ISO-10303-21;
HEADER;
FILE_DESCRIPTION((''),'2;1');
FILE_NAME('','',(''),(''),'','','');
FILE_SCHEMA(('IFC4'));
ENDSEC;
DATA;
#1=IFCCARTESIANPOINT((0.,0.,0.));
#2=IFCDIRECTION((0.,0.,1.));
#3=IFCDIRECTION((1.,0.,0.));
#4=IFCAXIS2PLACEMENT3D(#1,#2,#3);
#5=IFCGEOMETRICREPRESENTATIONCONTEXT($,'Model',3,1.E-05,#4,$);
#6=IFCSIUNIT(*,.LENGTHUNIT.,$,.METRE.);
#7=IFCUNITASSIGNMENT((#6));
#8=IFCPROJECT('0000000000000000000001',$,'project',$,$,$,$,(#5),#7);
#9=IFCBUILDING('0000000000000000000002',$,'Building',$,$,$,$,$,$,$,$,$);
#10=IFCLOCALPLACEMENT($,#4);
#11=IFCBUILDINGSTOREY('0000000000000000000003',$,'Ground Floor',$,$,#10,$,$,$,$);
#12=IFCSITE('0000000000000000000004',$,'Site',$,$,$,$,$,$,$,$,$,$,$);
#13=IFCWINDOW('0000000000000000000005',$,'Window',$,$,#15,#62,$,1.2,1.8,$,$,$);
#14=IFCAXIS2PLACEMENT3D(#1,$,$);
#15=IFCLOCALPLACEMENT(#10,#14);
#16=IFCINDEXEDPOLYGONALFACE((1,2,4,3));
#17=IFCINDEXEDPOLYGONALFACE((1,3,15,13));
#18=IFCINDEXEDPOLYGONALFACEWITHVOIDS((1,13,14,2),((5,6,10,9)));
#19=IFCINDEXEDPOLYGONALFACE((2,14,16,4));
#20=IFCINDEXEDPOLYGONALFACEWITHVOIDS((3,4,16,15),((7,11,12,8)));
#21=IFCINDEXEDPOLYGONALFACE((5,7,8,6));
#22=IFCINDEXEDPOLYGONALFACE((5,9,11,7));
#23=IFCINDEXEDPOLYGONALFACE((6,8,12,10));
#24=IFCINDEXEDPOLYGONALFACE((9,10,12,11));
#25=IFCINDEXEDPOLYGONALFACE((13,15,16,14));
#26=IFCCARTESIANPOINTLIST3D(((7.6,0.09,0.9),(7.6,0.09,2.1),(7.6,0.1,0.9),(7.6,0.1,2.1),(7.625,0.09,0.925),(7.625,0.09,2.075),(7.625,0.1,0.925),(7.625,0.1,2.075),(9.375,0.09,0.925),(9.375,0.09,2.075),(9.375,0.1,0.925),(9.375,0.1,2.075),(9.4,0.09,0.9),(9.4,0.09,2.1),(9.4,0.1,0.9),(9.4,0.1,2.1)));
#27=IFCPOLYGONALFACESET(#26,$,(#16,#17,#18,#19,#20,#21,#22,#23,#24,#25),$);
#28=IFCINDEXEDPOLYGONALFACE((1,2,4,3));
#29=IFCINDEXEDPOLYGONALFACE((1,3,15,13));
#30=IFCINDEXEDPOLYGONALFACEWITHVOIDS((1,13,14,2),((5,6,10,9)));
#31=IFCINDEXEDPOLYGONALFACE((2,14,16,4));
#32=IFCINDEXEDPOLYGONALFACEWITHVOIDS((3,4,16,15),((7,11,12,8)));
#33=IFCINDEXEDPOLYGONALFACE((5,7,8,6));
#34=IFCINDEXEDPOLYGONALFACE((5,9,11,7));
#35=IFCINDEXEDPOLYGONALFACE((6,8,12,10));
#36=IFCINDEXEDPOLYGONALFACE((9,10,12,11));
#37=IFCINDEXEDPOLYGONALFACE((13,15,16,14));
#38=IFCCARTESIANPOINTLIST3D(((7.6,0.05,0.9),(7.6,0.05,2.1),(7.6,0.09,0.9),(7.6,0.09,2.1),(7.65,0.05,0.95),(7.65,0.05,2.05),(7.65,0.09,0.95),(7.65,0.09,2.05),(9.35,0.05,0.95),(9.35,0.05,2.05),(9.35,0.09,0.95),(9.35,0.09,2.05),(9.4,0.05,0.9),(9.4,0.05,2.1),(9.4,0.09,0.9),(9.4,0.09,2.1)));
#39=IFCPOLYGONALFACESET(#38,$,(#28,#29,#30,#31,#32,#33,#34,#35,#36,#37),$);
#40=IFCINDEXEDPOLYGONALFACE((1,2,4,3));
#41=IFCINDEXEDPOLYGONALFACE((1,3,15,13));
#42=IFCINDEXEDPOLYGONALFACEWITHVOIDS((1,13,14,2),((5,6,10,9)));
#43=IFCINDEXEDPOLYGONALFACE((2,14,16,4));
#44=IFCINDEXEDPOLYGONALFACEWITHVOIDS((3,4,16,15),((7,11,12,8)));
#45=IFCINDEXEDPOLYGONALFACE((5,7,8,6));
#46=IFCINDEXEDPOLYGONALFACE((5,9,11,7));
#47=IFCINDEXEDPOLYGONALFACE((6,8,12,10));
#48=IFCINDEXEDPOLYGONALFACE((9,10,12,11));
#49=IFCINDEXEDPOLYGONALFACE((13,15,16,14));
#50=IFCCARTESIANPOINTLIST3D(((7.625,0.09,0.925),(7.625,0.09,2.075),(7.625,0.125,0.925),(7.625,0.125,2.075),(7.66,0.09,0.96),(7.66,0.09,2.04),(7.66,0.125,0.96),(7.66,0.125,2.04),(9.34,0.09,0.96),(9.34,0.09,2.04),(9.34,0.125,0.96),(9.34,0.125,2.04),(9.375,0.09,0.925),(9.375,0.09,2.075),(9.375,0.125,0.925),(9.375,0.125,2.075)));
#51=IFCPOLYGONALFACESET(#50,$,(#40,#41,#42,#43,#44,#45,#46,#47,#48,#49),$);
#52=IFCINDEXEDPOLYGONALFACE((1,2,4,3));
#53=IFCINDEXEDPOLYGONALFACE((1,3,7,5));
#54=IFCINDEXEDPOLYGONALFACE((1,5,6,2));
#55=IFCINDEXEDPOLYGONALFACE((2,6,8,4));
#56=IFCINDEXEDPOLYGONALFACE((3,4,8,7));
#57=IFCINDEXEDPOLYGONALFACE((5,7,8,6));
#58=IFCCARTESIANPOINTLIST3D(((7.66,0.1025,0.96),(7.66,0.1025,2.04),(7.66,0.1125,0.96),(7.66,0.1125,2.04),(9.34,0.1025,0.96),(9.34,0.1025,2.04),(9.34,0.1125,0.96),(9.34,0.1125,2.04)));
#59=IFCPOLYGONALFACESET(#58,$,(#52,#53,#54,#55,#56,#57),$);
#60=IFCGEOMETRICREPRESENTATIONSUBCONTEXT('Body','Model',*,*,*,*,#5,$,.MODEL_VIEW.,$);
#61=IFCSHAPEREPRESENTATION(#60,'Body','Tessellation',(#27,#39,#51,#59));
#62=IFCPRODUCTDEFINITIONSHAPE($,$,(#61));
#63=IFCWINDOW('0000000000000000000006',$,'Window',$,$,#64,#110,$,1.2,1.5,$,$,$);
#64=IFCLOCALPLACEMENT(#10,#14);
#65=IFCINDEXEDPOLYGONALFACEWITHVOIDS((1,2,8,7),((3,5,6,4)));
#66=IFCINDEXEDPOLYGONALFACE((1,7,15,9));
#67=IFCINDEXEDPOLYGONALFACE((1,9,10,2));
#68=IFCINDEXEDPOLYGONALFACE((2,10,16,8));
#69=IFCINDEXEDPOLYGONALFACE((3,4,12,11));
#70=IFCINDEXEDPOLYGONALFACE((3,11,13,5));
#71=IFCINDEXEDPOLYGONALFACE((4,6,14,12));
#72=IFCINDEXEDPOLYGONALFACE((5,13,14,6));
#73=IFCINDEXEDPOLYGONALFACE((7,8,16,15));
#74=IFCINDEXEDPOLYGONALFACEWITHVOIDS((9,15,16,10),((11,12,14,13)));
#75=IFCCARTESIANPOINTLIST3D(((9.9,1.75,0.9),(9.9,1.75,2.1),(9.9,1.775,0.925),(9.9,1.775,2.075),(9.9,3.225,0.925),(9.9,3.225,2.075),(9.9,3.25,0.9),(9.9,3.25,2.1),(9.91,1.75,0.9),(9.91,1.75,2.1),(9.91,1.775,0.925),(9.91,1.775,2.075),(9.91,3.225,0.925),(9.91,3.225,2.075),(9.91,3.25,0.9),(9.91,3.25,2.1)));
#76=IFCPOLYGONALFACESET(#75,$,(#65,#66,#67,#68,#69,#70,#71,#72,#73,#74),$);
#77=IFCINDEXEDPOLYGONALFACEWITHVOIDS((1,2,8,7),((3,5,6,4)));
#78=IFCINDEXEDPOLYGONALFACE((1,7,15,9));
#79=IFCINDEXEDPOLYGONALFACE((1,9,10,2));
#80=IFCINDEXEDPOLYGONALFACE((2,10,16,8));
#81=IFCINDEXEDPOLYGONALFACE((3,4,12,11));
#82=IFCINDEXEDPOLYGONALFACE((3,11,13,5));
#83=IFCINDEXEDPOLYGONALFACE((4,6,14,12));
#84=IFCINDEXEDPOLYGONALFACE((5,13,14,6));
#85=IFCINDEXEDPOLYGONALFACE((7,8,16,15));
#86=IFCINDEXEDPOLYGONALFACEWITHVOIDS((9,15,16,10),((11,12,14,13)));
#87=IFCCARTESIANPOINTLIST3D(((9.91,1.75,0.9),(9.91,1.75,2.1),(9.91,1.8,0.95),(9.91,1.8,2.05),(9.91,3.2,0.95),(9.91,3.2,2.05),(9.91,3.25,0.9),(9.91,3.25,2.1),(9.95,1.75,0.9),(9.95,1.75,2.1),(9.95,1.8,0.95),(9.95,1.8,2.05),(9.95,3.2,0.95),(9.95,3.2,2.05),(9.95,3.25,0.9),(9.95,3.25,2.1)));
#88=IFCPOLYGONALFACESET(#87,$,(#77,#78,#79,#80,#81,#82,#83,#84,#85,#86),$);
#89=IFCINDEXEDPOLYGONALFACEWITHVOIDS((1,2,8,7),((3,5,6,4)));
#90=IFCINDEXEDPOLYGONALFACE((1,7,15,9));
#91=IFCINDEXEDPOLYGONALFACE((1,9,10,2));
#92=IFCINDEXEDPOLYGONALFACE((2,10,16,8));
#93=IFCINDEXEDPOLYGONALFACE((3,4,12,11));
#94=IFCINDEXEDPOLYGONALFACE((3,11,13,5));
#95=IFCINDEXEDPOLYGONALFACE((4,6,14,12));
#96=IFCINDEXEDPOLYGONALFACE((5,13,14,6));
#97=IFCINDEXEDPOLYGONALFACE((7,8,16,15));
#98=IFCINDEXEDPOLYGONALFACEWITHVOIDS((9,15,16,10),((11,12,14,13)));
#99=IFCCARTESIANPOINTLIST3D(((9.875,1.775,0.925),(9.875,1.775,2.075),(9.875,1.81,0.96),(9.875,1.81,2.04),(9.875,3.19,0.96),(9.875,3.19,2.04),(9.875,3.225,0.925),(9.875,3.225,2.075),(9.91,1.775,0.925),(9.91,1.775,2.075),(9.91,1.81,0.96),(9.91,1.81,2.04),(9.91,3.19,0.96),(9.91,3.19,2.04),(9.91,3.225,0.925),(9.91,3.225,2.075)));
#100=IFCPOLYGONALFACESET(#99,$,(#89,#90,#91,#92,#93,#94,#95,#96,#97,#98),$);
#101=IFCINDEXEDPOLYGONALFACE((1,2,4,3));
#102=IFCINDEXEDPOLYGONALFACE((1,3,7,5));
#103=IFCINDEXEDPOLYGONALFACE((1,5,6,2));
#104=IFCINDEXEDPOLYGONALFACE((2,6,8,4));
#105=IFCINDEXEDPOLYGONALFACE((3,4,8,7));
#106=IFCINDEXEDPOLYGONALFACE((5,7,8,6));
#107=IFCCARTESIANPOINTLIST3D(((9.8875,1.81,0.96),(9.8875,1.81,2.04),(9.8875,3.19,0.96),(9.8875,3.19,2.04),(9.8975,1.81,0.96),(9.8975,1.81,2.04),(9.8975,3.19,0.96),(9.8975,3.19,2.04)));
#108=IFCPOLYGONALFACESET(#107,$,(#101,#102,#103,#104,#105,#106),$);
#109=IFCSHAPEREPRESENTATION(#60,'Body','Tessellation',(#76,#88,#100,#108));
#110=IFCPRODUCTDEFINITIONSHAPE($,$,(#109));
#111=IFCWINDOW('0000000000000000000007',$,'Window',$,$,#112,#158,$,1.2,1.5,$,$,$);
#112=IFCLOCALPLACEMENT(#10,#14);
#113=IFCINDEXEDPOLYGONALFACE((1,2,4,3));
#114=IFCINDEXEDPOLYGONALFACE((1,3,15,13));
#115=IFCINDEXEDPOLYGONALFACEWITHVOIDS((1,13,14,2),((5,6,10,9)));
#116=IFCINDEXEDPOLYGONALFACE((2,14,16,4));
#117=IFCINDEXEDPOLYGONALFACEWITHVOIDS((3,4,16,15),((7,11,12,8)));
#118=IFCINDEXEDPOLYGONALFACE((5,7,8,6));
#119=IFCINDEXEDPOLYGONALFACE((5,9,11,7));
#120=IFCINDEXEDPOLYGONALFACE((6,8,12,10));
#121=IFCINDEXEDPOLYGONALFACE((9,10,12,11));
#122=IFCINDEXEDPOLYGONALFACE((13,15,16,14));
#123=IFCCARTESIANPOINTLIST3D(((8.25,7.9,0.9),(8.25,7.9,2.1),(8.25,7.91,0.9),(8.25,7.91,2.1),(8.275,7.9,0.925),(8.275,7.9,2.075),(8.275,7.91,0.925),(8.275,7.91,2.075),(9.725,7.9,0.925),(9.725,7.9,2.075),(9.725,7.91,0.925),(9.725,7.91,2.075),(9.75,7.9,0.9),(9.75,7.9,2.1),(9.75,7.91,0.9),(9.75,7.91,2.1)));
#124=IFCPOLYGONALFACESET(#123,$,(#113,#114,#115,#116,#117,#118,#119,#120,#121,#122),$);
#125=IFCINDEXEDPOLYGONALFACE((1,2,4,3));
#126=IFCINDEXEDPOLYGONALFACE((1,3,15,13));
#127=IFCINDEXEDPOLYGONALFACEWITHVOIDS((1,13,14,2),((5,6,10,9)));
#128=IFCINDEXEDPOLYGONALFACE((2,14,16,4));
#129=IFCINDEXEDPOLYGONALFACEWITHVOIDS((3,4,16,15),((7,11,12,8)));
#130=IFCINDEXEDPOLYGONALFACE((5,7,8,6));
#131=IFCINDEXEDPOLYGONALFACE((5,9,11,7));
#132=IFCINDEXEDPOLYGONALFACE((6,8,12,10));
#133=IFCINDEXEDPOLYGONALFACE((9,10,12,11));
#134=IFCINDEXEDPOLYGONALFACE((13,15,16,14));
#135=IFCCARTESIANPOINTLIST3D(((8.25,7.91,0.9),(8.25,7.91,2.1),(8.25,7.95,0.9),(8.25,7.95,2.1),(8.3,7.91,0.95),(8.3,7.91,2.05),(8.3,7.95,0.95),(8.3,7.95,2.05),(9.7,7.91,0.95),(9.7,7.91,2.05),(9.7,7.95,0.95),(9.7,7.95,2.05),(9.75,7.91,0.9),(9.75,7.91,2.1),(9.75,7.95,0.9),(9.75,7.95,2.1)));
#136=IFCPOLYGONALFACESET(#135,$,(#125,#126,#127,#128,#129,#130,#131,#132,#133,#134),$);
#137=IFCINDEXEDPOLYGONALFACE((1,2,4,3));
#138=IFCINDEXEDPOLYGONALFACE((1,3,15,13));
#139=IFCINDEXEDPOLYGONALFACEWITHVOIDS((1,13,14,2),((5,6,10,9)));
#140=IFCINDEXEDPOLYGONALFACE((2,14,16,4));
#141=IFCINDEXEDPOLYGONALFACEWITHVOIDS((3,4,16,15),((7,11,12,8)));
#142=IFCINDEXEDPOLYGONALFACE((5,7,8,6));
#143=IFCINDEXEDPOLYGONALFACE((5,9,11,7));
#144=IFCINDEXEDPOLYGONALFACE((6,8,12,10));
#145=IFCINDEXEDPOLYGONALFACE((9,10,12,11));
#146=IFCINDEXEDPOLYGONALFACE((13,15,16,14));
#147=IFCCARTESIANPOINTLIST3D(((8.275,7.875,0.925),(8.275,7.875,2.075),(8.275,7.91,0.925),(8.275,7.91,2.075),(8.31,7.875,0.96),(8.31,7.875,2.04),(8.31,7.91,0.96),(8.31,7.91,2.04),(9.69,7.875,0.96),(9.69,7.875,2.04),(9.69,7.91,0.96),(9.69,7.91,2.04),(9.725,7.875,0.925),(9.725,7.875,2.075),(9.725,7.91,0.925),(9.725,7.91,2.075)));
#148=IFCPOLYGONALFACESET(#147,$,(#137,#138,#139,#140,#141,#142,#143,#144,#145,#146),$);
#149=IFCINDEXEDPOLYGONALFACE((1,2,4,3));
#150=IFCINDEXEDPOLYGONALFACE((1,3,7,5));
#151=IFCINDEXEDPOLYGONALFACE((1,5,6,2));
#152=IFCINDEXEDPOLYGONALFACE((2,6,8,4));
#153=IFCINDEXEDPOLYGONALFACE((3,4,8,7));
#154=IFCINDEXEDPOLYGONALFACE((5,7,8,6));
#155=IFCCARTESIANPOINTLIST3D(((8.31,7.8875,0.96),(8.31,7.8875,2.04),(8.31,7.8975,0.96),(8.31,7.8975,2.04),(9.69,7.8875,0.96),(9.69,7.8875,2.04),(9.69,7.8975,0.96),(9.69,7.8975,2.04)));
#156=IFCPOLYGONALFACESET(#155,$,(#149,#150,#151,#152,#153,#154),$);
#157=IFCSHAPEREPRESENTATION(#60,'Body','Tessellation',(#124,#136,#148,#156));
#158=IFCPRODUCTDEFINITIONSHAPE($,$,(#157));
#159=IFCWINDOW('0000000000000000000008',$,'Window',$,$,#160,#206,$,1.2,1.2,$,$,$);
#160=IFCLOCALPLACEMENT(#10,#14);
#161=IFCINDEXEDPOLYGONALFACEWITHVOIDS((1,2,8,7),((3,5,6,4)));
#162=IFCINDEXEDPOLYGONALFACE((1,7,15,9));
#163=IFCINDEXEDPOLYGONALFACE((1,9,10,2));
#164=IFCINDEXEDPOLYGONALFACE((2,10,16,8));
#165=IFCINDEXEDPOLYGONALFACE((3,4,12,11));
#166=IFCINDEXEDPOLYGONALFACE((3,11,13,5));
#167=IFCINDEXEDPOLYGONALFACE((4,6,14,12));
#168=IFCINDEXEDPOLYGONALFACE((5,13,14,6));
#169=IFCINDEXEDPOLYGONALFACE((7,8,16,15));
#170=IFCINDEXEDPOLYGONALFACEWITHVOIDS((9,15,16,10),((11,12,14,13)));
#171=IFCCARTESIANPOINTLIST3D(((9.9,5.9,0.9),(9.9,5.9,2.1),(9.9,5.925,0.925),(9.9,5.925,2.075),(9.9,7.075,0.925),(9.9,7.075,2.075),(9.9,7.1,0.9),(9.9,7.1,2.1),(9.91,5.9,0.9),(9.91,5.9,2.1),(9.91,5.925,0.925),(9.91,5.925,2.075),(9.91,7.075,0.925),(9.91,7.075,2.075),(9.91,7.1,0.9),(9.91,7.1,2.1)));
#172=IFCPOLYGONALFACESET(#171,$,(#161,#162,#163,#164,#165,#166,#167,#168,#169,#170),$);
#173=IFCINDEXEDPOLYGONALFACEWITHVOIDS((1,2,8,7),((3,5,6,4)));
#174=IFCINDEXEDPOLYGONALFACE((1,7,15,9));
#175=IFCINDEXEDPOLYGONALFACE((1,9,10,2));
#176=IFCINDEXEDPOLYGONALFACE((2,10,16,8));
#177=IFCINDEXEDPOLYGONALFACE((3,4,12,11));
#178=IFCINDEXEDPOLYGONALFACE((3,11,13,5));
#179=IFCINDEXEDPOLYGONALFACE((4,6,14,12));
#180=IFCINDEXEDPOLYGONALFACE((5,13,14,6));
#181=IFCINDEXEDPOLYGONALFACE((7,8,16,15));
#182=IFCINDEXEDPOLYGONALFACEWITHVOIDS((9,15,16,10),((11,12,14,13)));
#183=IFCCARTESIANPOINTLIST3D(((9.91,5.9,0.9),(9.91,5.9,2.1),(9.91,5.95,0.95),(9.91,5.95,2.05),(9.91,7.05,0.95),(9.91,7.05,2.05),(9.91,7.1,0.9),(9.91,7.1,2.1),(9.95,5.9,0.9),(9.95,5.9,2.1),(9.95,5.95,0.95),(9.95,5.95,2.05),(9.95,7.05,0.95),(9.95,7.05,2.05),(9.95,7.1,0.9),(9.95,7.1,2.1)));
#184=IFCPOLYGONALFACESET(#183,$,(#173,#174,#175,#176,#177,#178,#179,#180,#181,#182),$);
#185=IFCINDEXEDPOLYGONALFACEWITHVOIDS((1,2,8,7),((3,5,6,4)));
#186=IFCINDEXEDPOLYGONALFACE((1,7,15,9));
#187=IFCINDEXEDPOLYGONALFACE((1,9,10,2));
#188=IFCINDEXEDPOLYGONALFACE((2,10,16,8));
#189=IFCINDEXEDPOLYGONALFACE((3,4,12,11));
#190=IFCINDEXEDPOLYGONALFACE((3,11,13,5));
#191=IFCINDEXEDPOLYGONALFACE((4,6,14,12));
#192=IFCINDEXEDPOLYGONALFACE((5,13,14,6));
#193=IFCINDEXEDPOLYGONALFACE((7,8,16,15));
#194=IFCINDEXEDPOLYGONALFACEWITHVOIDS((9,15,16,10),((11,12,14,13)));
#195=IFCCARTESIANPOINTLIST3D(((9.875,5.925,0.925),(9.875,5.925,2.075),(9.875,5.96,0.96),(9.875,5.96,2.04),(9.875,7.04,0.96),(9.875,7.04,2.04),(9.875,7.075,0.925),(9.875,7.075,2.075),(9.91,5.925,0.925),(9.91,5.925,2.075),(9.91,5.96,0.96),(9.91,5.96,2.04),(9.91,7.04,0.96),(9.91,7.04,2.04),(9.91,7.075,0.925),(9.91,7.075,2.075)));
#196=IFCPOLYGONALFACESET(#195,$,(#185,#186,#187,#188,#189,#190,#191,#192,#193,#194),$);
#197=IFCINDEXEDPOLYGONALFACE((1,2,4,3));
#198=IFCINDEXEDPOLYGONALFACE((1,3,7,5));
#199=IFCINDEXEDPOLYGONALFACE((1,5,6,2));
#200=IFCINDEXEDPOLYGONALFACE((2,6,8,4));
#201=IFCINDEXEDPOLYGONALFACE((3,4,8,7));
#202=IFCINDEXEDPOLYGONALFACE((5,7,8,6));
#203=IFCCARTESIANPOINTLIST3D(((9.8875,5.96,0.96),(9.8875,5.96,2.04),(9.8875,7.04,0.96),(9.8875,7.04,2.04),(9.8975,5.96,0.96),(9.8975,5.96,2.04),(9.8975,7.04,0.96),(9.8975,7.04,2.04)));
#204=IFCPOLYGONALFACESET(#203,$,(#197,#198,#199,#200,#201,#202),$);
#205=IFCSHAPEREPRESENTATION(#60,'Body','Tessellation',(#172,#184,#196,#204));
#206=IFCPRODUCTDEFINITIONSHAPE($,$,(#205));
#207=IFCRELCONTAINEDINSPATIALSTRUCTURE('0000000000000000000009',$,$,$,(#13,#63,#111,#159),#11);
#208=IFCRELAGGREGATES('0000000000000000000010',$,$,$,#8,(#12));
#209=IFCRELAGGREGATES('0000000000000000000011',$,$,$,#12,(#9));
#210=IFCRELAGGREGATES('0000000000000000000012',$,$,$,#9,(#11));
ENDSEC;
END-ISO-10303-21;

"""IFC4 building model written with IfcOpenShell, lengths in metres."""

from ifc_helpers import new_model, si_unit, frame, origin_with_axes, place, context, subcontext, project, spatial, line, indexed_curve, outline, extrude, element, save


model = new_model("IFC4")

# Units and contexts
model_context = context("Model", 3, precision=1e-05, world=origin_with_axes())
body_context = subcontext(model_context, "Body", "Model", "MODEL_VIEW")
ifc_project = project(units=[si_unit("LENGTHUNIT", "METRE")], contexts=[model_context])

# Site, building, storey
site = spatial("IfcSite", under=ifc_project, Name="Site")
building = spatial("IfcBuilding", under=site, Name="Building")
storey_placement = place(None, origin_with_axes())
storey = spatial("IfcBuildingStorey", under=building, at=storey_placement, Name="Ground Floor")

# Windows
window_1_placement = place(storey_placement, frame((7.6, 0.0, 0.9), z_axis=(0.0, 0.0, 1.0), x_axis=(1.0, 0.0, 0.0)))
element("IfcWindow", 1, at=window_1_placement, inside=storey, Name="Window", OverallHeight=1.2, OverallWidth=1.8, context=body_context, shape_type="SweptSolid", body=[
    extrude(outline(indexed_curve([(0.0, 0.0), (1.8, 0.0), (1.8, 1.2), (0.0, 1.2)], segments=[line(1, 2, 3, 4, 1)]), holes=[indexed_curve([(0.025, 0.025), (1.775, 0.025), (1.775, 1.175), (0.025, 1.175)], segments=[line(1, 2, 3, 4, 1)])]), frame((0.0, 0.09, 0.0), z_axis=(0.0, -1.0, 0.0), x_axis=(1.0, 0.0, 0.0)), (0.0, 0.0, -1.0), 0.01),
    extrude(outline(indexed_curve([(0.0, 0.0), (1.8, 0.0), (1.8, 1.2), (0.0, 1.2)], segments=[line(1, 2, 3, 4, 1)]), holes=[indexed_curve([(0.05, 0.05), (1.75, 0.05), (1.75, 1.15), (0.05, 1.15)], segments=[line(1, 2, 3, 4, 1)])]), frame((0.0, 0.05, 0.0), z_axis=(0.0, -1.0, 0.0), x_axis=(1.0, 0.0, 0.0)), (0.0, 0.0, -1.0), 0.04),
    extrude(outline(indexed_curve([(0.0, 0.0), (1.75, 0.0), (1.75, 1.15), (0.0, 1.15)], segments=[line(1, 2, 3, 4, 1)]), holes=[indexed_curve([(0.035, 0.035), (1.715, 0.035), (1.715, 1.115), (0.035, 1.115)], segments=[line(1, 2, 3, 4, 1)])]), frame((0.025, 0.09, 0.025), z_axis=(0.0, -1.0, 0.0), x_axis=(1.0, 0.0, 0.0)), (0.0, 0.0, -1.0), 0.035),
    extrude(outline(indexed_curve([(0.035, 0.035), (1.715, 0.035), (1.715, 1.115), (0.035, 1.115)], segments=[line(1, 2, 3, 4, 1)])), frame((0.025, 0.1025, 0.025), z_axis=(0.0, -1.0, 0.0), x_axis=(1.0, 0.0, 0.0)), (0.0, 0.0, -1.0), 0.01),
])
for number, where, z_axis, x_axis, name in (
    (2, (10.0, 1.75, 0.9), (0.0, 0.0, 1.0), (0.0, 1.0, 0.0), "Window"),
    (3, (9.75, 8.0, 0.9), (0.0, 0.0, 1.0), (-1.0, 0.0, 0.0), "Window"),
):
    element("IfcWindow", number, at=place(storey_placement, frame(where, z_axis=z_axis, x_axis=x_axis)), inside=storey, Name=name, OverallHeight=1.2, OverallWidth=1.5, context=body_context, shape_type="SweptSolid", body=[
        extrude(outline(indexed_curve([(0.0, 0.0), (1.5, 0.0), (1.5, 1.2), (0.0, 1.2)], segments=[line(1, 2, 3, 4, 1)]), holes=[indexed_curve([(0.025, 0.025), (1.475, 0.025), (1.475, 1.175), (0.025, 1.175)], segments=[line(1, 2, 3, 4, 1)])]), frame((0.0, 0.09, 0.0), z_axis=(0.0, -1.0, 0.0), x_axis=(1.0, 0.0, 0.0)), (0.0, 0.0, -1.0), 0.01),
        extrude(outline(indexed_curve([(0.0, 0.0), (1.5, 0.0), (1.5, 1.2), (0.0, 1.2)], segments=[line(1, 2, 3, 4, 1)]), holes=[indexed_curve([(0.05, 0.05), (1.45, 0.05), (1.45, 1.15), (0.05, 1.15)], segments=[line(1, 2, 3, 4, 1)])]), frame((0.0, 0.05, 0.0), z_axis=(0.0, -1.0, 0.0), x_axis=(1.0, 0.0, 0.0)), (0.0, 0.0, -1.0), 0.04),
        extrude(outline(indexed_curve([(0.0, 0.0), (1.45, 0.0), (1.45, 1.15), (0.0, 1.15)], segments=[line(1, 2, 3, 4, 1)]), holes=[indexed_curve([(0.035, 0.035), (1.415, 0.035), (1.415, 1.115), (0.035, 1.115)], segments=[line(1, 2, 3, 4, 1)])]), frame((0.025, 0.09, 0.025), z_axis=(0.0, -1.0, 0.0), x_axis=(1.0, 0.0, 0.0)), (0.0, 0.0, -1.0), 0.035),
        extrude(outline(indexed_curve([(0.035, 0.035), (1.415, 0.035), (1.415, 1.115), (0.035, 1.115)], segments=[line(1, 2, 3, 4, 1)])), frame((0.025, 0.1025, 0.025), z_axis=(0.0, -1.0, 0.0), x_axis=(1.0, 0.0, 0.0)), (0.0, 0.0, -1.0), 0.01),
    ])
window_2_placement = place(storey_placement, frame((10.0, 5.9, 0.9), z_axis=(0.0, 0.0, 1.0), x_axis=(0.0, 1.0, 0.0)))
element("IfcWindow", 4, at=window_2_placement, inside=storey, Name="Window", OverallHeight=1.2, OverallWidth=1.2, context=body_context, shape_type="SweptSolid", body=[
    extrude(outline(indexed_curve([(0.0, 0.0), (1.2, 0.0), (1.2, 1.2), (0.0, 1.2)], segments=[line(1, 2, 3, 4, 1)]), holes=[indexed_curve([(0.025, 0.025), (1.175, 0.025), (1.175, 1.175), (0.025, 1.175)], segments=[line(1, 2, 3, 4, 1)])]), frame((0.0, 0.09, 0.0), z_axis=(0.0, -1.0, 0.0), x_axis=(1.0, 0.0, 0.0)), (0.0, 0.0, -1.0), 0.01),
    extrude(outline(indexed_curve([(0.0, 0.0), (1.2, 0.0), (1.2, 1.2), (0.0, 1.2)], segments=[line(1, 2, 3, 4, 1)]), holes=[indexed_curve([(0.05, 0.05), (1.15, 0.05), (1.15, 1.15), (0.05, 1.15)], segments=[line(1, 2, 3, 4, 1)])]), frame((0.0, 0.05, 0.0), z_axis=(0.0, -1.0, 0.0), x_axis=(1.0, 0.0, 0.0)), (0.0, 0.0, -1.0), 0.04),
    extrude(outline(indexed_curve([(0.0, 0.0), (1.15, 0.0), (1.15, 1.15), (0.0, 1.15)], segments=[line(1, 2, 3, 4, 1)]), holes=[indexed_curve([(0.035, 0.035), (1.115, 0.035), (1.115, 1.115), (0.035, 1.115)], segments=[line(1, 2, 3, 4, 1)])]), frame((0.025, 0.09, 0.025), z_axis=(0.0, -1.0, 0.0), x_axis=(1.0, 0.0, 0.0)), (0.0, 0.0, -1.0), 0.035),
    extrude(outline(indexed_curve([(0.035, 0.035), (1.115, 0.035), (1.115, 1.115), (0.035, 1.115)], segments=[line(1, 2, 3, 4, 1)])), frame((0.025, 0.1025, 0.025), z_axis=(0.0, -1.0, 0.0), x_axis=(1.0, 0.0, 0.0)), (0.0, 0.0, -1.0), 0.01),
])

save(model, "model.ifc")
